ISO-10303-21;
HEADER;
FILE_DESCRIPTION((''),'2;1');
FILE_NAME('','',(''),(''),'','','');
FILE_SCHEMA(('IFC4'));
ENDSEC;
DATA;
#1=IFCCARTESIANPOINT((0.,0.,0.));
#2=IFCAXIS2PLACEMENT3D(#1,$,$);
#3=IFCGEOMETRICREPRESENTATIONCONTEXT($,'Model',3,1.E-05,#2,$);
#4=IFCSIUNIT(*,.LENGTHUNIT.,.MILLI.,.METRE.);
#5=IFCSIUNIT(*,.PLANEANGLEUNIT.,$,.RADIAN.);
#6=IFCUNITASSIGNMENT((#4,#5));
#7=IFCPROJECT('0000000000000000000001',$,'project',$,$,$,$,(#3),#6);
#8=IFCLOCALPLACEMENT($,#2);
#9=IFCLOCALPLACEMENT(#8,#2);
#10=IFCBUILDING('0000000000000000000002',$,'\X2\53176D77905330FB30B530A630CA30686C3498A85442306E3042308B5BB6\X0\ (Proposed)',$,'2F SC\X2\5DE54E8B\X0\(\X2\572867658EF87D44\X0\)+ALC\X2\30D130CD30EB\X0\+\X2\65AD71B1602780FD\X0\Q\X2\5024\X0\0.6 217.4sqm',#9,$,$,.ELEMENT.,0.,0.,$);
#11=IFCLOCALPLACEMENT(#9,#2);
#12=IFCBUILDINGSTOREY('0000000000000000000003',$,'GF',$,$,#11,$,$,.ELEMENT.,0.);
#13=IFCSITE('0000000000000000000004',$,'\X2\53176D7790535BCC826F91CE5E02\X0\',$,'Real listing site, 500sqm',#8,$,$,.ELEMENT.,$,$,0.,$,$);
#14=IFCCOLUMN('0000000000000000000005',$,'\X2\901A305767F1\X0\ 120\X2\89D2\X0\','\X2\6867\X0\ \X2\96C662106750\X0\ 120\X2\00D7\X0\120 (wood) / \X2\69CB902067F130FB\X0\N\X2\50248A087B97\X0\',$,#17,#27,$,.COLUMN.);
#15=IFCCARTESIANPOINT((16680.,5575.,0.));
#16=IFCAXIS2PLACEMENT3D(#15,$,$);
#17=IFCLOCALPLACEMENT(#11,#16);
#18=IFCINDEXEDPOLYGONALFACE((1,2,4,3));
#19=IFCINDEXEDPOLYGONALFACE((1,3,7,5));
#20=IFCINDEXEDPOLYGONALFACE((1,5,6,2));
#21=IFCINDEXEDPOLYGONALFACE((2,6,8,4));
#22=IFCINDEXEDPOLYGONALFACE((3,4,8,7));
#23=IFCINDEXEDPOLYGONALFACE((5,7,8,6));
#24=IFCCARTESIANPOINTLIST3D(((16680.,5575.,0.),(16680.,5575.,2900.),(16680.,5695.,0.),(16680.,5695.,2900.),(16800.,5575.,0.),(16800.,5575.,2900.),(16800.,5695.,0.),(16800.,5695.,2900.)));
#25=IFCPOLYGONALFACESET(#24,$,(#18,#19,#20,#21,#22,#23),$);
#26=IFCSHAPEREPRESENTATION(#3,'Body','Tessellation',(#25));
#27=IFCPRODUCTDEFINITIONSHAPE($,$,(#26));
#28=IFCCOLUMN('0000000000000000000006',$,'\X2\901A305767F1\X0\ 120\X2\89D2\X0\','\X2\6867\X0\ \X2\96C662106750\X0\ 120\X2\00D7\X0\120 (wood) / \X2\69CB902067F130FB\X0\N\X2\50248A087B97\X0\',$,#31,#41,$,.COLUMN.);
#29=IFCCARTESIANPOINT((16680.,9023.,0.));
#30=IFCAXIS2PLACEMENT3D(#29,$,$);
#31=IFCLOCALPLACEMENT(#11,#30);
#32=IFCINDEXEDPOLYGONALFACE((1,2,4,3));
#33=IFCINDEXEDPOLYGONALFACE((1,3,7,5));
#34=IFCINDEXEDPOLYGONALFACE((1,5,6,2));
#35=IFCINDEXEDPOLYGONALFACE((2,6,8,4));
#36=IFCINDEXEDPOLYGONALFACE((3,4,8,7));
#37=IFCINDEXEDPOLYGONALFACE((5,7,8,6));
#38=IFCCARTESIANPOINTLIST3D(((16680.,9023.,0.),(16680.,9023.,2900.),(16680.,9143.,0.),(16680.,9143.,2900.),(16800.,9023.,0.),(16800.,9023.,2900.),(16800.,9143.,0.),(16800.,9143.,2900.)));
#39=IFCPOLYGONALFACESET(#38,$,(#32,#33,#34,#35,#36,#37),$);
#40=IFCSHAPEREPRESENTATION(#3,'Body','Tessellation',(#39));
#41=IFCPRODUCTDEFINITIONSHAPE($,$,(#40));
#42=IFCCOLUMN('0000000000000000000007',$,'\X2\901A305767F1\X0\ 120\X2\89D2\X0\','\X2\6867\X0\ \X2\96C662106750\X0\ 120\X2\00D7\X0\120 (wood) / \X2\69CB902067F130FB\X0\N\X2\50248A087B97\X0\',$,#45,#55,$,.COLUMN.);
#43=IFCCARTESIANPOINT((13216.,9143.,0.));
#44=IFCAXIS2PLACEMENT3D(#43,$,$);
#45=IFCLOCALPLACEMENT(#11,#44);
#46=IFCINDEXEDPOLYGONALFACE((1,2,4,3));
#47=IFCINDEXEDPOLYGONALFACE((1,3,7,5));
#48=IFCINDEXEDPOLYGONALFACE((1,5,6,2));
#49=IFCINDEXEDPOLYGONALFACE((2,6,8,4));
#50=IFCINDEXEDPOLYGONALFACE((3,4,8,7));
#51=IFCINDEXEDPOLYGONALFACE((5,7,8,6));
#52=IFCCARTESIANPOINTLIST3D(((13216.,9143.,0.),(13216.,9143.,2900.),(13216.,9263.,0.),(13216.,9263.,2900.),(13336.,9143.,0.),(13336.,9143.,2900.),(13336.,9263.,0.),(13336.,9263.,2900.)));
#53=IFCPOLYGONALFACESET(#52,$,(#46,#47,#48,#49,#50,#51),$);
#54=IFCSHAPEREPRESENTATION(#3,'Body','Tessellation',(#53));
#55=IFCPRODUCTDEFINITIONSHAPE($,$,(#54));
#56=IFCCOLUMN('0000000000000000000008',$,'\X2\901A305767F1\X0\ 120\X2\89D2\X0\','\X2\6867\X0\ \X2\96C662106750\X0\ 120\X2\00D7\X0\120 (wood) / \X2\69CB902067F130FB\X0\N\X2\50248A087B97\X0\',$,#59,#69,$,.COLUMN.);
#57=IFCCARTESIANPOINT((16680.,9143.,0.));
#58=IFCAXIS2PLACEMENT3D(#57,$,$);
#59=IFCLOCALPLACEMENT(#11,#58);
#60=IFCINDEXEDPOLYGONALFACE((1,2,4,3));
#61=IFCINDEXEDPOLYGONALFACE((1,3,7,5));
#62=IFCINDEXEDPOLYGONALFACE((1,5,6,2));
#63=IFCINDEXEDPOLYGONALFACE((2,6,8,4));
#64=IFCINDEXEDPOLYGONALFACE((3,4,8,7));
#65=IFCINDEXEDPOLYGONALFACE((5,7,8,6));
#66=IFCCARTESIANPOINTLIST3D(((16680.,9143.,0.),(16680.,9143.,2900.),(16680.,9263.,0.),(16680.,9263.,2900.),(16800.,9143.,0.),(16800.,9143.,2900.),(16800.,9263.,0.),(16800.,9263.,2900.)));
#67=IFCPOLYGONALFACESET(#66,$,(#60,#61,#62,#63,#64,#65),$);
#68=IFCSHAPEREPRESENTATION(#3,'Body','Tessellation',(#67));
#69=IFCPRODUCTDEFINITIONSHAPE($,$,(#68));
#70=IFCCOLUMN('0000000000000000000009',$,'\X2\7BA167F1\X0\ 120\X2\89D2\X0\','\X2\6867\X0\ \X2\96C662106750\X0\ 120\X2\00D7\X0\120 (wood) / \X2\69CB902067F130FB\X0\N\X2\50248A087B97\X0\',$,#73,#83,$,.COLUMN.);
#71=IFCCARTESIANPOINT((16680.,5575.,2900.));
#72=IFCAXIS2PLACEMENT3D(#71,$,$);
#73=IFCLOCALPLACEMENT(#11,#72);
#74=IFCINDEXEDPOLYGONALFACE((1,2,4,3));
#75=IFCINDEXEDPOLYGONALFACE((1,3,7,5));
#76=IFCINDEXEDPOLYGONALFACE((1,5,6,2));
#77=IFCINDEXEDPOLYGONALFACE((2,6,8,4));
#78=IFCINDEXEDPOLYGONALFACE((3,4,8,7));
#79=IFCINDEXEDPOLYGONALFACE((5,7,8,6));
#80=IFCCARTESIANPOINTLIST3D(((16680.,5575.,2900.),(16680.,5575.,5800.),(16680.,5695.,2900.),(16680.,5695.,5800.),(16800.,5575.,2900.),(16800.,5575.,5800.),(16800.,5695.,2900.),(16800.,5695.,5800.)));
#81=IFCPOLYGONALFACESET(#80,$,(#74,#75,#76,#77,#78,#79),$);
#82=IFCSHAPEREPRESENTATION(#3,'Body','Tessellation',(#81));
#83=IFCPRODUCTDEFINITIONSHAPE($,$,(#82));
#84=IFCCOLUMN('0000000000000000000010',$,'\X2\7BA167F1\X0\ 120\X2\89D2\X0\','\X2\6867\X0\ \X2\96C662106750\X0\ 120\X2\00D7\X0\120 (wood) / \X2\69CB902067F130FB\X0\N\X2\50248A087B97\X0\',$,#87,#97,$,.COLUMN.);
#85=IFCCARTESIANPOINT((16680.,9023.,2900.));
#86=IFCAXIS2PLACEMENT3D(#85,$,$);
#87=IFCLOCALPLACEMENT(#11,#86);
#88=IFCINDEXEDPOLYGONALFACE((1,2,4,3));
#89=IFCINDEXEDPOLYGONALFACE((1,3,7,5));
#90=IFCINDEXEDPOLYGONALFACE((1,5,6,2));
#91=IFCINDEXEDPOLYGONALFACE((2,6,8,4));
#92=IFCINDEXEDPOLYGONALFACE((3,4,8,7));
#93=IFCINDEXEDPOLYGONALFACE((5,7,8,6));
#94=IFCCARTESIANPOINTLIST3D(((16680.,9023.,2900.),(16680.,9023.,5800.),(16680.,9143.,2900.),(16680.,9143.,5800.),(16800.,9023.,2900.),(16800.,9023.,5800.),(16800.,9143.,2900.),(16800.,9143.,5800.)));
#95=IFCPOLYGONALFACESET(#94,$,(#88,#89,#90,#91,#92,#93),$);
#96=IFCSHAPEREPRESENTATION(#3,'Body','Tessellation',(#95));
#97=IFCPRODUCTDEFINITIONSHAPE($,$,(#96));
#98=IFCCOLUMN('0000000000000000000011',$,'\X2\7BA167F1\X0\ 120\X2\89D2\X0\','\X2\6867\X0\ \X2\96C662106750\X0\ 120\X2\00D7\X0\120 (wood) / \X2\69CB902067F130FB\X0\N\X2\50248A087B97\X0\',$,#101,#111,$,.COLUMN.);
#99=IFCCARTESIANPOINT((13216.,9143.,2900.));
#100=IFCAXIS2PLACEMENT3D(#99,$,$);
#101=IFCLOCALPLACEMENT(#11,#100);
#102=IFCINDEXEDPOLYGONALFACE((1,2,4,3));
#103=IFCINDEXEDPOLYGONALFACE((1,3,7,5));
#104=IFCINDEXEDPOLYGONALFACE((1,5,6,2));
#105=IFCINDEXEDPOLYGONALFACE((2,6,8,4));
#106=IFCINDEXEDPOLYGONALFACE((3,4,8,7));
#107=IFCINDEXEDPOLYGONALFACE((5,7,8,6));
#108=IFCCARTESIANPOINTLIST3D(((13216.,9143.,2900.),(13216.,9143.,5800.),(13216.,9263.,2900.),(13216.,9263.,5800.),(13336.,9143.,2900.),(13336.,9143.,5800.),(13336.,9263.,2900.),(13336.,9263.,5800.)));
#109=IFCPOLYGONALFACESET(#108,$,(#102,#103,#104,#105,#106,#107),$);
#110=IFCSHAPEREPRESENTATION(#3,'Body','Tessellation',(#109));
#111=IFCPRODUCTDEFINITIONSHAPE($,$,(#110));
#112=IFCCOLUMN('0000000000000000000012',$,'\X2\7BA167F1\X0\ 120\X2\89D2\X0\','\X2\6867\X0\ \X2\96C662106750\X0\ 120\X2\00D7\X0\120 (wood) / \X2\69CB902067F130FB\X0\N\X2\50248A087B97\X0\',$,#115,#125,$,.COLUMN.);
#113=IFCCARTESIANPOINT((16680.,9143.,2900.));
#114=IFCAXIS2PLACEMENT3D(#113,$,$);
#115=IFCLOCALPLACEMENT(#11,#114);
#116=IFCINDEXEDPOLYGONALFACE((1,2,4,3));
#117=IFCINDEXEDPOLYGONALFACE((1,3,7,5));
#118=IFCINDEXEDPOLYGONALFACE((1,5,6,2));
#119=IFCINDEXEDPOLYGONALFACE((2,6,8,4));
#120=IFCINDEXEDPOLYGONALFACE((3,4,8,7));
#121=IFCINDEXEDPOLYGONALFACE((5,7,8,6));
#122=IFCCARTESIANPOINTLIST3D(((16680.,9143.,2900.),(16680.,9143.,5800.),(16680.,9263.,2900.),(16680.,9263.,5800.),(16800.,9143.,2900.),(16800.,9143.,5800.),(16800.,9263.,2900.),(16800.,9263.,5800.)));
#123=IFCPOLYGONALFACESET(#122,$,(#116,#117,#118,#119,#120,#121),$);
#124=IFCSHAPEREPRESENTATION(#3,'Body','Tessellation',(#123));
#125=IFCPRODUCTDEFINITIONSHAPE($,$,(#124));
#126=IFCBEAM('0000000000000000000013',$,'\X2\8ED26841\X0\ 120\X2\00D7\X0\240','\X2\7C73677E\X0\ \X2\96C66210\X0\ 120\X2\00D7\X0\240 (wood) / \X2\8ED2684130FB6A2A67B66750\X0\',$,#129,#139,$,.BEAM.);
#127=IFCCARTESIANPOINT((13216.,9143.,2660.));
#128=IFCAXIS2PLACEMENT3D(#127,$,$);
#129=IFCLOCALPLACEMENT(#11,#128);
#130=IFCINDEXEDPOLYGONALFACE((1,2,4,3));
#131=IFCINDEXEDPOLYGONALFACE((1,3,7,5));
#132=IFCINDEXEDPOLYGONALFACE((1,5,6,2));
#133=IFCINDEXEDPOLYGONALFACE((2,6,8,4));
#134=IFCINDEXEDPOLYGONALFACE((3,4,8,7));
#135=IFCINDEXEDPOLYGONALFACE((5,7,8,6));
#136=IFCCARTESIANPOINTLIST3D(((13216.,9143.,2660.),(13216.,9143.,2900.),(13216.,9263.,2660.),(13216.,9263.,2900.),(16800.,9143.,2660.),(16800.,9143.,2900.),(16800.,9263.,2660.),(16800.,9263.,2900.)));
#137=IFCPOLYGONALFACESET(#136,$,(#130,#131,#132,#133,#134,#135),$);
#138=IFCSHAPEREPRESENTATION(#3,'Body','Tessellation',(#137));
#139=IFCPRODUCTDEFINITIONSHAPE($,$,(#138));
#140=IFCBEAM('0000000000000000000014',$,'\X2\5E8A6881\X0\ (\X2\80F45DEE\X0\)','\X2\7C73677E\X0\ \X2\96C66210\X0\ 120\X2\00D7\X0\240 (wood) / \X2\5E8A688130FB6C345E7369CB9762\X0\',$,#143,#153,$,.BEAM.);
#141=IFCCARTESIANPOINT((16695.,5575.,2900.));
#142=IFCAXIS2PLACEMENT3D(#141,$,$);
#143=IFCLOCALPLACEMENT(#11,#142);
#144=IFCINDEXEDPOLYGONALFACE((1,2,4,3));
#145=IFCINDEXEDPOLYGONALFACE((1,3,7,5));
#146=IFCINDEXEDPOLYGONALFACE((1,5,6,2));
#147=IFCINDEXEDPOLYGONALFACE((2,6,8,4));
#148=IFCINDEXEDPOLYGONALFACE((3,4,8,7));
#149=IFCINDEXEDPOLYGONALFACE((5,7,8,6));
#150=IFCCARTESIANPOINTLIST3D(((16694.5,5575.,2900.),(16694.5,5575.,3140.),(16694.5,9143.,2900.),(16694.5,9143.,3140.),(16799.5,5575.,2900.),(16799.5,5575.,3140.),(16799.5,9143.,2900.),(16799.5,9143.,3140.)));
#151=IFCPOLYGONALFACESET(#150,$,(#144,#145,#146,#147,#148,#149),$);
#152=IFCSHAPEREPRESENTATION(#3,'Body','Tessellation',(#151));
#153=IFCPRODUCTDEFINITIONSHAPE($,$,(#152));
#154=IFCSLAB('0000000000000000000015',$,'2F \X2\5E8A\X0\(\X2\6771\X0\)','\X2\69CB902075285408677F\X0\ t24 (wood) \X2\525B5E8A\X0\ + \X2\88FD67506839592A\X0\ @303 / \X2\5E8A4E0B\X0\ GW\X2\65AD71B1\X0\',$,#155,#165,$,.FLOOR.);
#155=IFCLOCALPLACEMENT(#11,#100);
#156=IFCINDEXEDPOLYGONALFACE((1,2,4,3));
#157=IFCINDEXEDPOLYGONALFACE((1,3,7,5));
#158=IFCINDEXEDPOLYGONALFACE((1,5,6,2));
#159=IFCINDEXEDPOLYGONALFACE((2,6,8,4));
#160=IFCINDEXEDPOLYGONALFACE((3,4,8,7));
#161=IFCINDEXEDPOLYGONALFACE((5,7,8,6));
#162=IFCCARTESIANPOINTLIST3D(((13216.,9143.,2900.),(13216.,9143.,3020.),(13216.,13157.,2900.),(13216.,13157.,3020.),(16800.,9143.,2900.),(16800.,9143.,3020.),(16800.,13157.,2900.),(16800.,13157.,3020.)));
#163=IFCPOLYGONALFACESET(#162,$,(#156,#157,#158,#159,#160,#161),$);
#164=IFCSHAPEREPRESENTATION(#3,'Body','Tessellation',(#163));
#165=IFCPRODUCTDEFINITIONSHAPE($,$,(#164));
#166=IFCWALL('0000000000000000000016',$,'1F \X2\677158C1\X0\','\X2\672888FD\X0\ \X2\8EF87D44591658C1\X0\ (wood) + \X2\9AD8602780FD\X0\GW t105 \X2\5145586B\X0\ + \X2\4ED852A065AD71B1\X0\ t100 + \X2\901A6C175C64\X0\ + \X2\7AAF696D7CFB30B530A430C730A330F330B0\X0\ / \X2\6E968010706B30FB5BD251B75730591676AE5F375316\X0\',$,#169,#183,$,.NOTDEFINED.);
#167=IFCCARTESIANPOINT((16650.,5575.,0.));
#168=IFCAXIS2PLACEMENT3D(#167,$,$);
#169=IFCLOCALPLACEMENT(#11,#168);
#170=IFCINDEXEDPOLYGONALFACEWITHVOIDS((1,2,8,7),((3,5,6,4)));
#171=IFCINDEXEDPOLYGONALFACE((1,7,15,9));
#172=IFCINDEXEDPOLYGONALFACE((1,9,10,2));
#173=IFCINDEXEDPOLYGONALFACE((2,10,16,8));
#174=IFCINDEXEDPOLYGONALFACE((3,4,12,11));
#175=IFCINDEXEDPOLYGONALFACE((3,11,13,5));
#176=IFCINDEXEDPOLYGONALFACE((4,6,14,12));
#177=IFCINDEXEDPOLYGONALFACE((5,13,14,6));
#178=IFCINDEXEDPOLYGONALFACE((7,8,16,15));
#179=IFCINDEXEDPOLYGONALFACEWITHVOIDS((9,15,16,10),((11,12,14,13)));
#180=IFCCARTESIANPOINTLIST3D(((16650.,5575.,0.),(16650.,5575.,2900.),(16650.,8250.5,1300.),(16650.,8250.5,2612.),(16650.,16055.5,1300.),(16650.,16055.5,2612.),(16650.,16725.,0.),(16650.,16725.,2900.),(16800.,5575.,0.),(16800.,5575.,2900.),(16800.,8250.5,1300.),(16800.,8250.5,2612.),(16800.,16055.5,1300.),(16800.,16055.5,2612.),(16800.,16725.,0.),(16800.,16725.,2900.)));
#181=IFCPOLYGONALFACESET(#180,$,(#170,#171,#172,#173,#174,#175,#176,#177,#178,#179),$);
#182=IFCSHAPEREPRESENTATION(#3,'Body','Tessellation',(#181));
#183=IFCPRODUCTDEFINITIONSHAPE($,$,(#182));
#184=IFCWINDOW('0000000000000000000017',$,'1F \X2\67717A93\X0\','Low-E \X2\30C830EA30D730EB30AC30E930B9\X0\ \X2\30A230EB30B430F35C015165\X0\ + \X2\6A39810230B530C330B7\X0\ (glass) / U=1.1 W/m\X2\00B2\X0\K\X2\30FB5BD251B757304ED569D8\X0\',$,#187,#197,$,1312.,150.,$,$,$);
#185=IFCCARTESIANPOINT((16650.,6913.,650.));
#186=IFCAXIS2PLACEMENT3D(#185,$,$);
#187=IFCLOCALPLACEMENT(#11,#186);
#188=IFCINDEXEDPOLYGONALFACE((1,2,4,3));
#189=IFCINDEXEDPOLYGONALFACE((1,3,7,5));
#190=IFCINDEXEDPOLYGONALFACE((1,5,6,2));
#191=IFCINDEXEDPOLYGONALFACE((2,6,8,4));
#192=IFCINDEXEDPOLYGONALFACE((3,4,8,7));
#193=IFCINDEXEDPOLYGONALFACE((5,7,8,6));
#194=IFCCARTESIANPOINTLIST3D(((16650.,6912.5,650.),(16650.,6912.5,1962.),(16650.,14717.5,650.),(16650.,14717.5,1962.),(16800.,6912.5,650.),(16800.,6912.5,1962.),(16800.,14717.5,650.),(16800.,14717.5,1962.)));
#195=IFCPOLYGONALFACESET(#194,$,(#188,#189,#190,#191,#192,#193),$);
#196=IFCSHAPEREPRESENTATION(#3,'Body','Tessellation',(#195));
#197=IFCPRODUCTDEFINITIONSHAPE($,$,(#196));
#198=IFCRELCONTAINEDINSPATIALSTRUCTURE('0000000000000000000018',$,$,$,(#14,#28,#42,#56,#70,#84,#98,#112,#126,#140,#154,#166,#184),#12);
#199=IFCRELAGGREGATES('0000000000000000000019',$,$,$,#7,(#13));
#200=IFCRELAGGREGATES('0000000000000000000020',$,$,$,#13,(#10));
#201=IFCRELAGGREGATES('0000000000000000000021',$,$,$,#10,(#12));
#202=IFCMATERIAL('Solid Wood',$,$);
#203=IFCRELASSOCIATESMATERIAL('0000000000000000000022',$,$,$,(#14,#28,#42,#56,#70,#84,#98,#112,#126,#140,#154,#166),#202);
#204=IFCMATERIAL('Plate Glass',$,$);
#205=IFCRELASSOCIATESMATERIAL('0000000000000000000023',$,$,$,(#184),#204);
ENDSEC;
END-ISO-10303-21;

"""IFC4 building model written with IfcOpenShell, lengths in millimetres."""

from ifc_helpers import new_model, si_unit, frame, frame_2d, origin, place, context, project, spatial, rectangle, extrude, material, element, fill, save


model = new_model("IFC4")

# Units and contexts
model_context = context("Model", 3, precision=1e-05, world=origin())
ifc_project = project(units=[si_unit("LENGTHUNIT", "METRE", prefix="MILLI"), si_unit("PLANEANGLEUNIT", "RADIAN")], contexts=[model_context])

# Site, building, storey
site_placement = place(None, origin())
site = spatial("IfcSite", under=ifc_project, at=site_placement, Name="北海道富良野市", ObjectType="Real listing site, 500sqm", CompositionType="ELEMENT", RefElevation=0.0)
building_placement = place(site_placement, origin())
building = spatial("IfcBuilding", under=site, at=building_placement, Name="北海道・サウナと水風呂のある家 (Proposed)", ObjectType="2F SC工事(在来軸組)+ALCパネル+断熱性能Q値0.6 217.4sqm", CompositionType="ELEMENT", ElevationOfRefHeight=0.0, ElevationOfTerrain=0.0)
storey_placement = place(building_placement, origin())
storey = spatial("IfcBuildingStorey", under=building, at=storey_placement, Name="GF", CompositionType="ELEMENT", Elevation=0.0)

# Columns
ifc_material_1 = material(Name="Solid Wood")
column_1_placement = place(storey_placement, frame((16680.0, 5575.0, 0.0)))
element("IfcColumn", 1, at=column_1_placement, inside=storey, material=ifc_material_1, Name="通し柱 120角", Description="桧 集成材 120×120 (wood) / 構造柱・N値計算", PredefinedType="COLUMN", context=model_context, shape_type="SweptSolid", body=[
    extrude(rectangle(XDim=120.0, YDim=120.0, at=frame_2d((60.0, 60.0))), frame((16680.0, 5575.0, 0.0)), (0.0, 0.0, 1.0), 2900.0),
])
column_2_placement = place(storey_placement, frame((16680.0, 9023.0, 0.0)))
element("IfcColumn", 2, at=column_2_placement, inside=storey, material=ifc_material_1, Name="通し柱 120角", Description="桧 集成材 120×120 (wood) / 構造柱・N値計算", PredefinedType="COLUMN", context=model_context, shape_type="SweptSolid", body=[
    extrude(rectangle(XDim=120.0, YDim=120.0, at=frame_2d((60.0, 60.0))), frame((16680.0, 9023.0, 0.0)), (0.0, 0.0, 1.0), 2900.0),
])
column_3_placement = place(storey_placement, frame((13216.0, 9143.0, 0.0)))
element("IfcColumn", 3, at=column_3_placement, inside=storey, material=ifc_material_1, Name="通し柱 120角", Description="桧 集成材 120×120 (wood) / 構造柱・N値計算", PredefinedType="COLUMN", context=model_context, shape_type="SweptSolid", body=[
    extrude(rectangle(XDim=120.0, YDim=120.0, at=frame_2d((60.0, 60.0))), frame((13216.0, 9143.0, 0.0)), (0.0, 0.0, 1.0), 2900.0),
])
column_4_placement = place(storey_placement, frame((16680.0, 9143.0, 0.0)))
element("IfcColumn", 4, at=column_4_placement, inside=storey, material=ifc_material_1, Name="通し柱 120角", Description="桧 集成材 120×120 (wood) / 構造柱・N値計算", PredefinedType="COLUMN", context=model_context, shape_type="SweptSolid", body=[
    extrude(rectangle(XDim=120.0, YDim=120.0, at=frame_2d((60.0, 60.0))), frame((16680.0, 9143.0, 0.0)), (0.0, 0.0, 1.0), 2900.0),
])
column_5_placement = place(storey_placement, frame((16680.0, 5575.0, 2900.0)))
element("IfcColumn", 5, at=column_5_placement, inside=storey, material=ifc_material_1, Name="管柱 120角", Description="桧 集成材 120×120 (wood) / 構造柱・N値計算", PredefinedType="COLUMN", context=model_context, shape_type="SweptSolid", body=[
    extrude(rectangle(XDim=120.0, YDim=120.0, at=frame_2d((60.0, 60.0))), frame((16680.0, 5575.0, 2900.0)), (0.0, 0.0, 1.0), 2900.0),
])
column_6_placement = place(storey_placement, frame((16680.0, 9023.0, 2900.0)))
element("IfcColumn", 6, at=column_6_placement, inside=storey, material=ifc_material_1, Name="管柱 120角", Description="桧 集成材 120×120 (wood) / 構造柱・N値計算", PredefinedType="COLUMN", context=model_context, shape_type="SweptSolid", body=[
    extrude(rectangle(XDim=120.0, YDim=120.0, at=frame_2d((60.0, 60.0))), frame((16680.0, 9023.0, 2900.0)), (0.0, 0.0, 1.0), 2900.0),
])
column_7_placement = place(storey_placement, frame((13216.0, 9143.0, 2900.0)))
element("IfcColumn", 7, at=column_7_placement, inside=storey, material=ifc_material_1, Name="管柱 120角", Description="桧 集成材 120×120 (wood) / 構造柱・N値計算", PredefinedType="COLUMN", context=model_context, shape_type="SweptSolid", body=[
    extrude(rectangle(XDim=120.0, YDim=120.0, at=frame_2d((60.0, 60.0))), frame((13216.0, 9143.0, 2900.0)), (0.0, 0.0, 1.0), 2900.0),
])
column_8_placement = place(storey_placement, frame((16680.0, 9143.0, 2900.0)))
element("IfcColumn", 8, at=column_8_placement, inside=storey, material=ifc_material_1, Name="管柱 120角", Description="桧 集成材 120×120 (wood) / 構造柱・N値計算", PredefinedType="COLUMN", context=model_context, shape_type="SweptSolid", body=[
    extrude(rectangle(XDim=120.0, YDim=120.0, at=frame_2d((60.0, 60.0))), frame((16680.0, 9143.0, 2900.0)), (0.0, 0.0, 1.0), 2900.0),
])

# Beams
beam_1_placement = place(storey_placement, frame((13216.0, 9143.0, 2660.0)))
element("IfcBeam", 9, at=beam_1_placement, inside=storey, material=ifc_material_1, Name="軒桁 120×240", Description="米松 集成 120×240 (wood) / 軒桁・横架材", PredefinedType="BEAM", context=model_context, shape_type="SweptSolid", body=[
    extrude(rectangle(XDim=3584.0, YDim=120.0, at=frame_2d((1792.0, 60.0))), frame((13216.0, 9143.0, 2660.0)), (0.0, 0.0, 1.0), 240.0),
])
beam_2_placement = place(storey_placement, frame((16695.0, 5575.0, 2900.0)))
element("IfcBeam", 10, at=beam_2_placement, inside=storey, material=ifc_material_1, Name="床梁 (胴差)", Description="米松 集成 120×240 (wood) / 床梁・水平構面", PredefinedType="BEAM", context=model_context, shape_type="SweptSolid", body=[
    extrude(rectangle(XDim=105.0, YDim=3568.0, at=frame_2d((52.0, 1784.0))), frame((16695.0, 5575.0, 2900.0)), (0.0, 0.0, 1.0), 240.0),
])

# Slab
slab_placement = place(storey_placement, frame((13216.0, 9143.0, 2900.0)))
element("IfcSlab", 11, at=slab_placement, inside=storey, material=ifc_material_1, Name="2F 床(東)", Description="構造用合板 t24 (wood) 剛床 + 製材根太 @303 / 床下 GW断熱", PredefinedType="FLOOR", context=model_context, shape_type="SweptSolid", body=[
    extrude(rectangle(XDim=3584.0, YDim=4014.0, at=frame_2d((1792.0, 2007.0))), frame((13216.0, 9143.0, 2900.0)), (0.0, 0.0, 1.0), 120.0),
])

# Wall, opening, window
wall_1_placement = place(storey_placement, frame((16650.0, 5575.0, 0.0)))
wall_1 = element("IfcWall", 12, at=wall_1_placement, inside=storey, material=ifc_material_1, Name="1F 東壁", Description="木製 軸組外壁 (wood) + 高性能GW t105 充填 + 付加断熱 t100 + 通気層 + 窯業系サイディング / 準耐火・寒冷地外皮強化", PredefinedType="NOTDEFINED", context=model_context, shape_type="SweptSolid", body=[
    extrude(rectangle(XDim=150.0, YDim=11150.0, at=frame_2d((75.0, 5575.0))), frame((16650.0, 5575.0, 0.0)), (0.0, 0.0, 1.0), 2900.0),
])
opening_1_placement = place(storey_placement, frame((16650.0, 6913.0, 650.0)))
opening_1 = element("IfcOpeningElement", 13, at=opening_1_placement, cuts=wall_1, PredefinedType="NOTDEFINED", context=model_context, shape_type="SweptSolid", body=[
    extrude(rectangle(XDim=150.0, YDim=7805.0, at=frame_2d((75.0, 3902.0))), frame((16650.0, 6913.0, 650.0)), (0.0, 0.0, 1.0), 1312.0),
])
ifc_material_2 = material(Name="Plate Glass")
window_1_placement = place(storey_placement, frame((16650.0, 6913.0, 650.0)))
window_1 = element("IfcWindow", 14, at=window_1_placement, inside=storey, material=ifc_material_2, Name="1F 東窓", Description="Low-E トリプルガラス アルゴン封入 + 樹脂サッシ (glass) / U=1.1 W/m²K・寒冷地仕様", OverallHeight=1312.0, OverallWidth=150.0, context=model_context, shape_type="SweptSolid", body=[
    extrude(rectangle(XDim=150.0, YDim=7805.0, at=frame_2d((75.0, 3902.0))), frame((16650.0, 6913.0, 650.0)), (0.0, 0.0, 1.0), 1312.0),
])
fill(opening_1, window_1)

save(model, "model.ifc")
